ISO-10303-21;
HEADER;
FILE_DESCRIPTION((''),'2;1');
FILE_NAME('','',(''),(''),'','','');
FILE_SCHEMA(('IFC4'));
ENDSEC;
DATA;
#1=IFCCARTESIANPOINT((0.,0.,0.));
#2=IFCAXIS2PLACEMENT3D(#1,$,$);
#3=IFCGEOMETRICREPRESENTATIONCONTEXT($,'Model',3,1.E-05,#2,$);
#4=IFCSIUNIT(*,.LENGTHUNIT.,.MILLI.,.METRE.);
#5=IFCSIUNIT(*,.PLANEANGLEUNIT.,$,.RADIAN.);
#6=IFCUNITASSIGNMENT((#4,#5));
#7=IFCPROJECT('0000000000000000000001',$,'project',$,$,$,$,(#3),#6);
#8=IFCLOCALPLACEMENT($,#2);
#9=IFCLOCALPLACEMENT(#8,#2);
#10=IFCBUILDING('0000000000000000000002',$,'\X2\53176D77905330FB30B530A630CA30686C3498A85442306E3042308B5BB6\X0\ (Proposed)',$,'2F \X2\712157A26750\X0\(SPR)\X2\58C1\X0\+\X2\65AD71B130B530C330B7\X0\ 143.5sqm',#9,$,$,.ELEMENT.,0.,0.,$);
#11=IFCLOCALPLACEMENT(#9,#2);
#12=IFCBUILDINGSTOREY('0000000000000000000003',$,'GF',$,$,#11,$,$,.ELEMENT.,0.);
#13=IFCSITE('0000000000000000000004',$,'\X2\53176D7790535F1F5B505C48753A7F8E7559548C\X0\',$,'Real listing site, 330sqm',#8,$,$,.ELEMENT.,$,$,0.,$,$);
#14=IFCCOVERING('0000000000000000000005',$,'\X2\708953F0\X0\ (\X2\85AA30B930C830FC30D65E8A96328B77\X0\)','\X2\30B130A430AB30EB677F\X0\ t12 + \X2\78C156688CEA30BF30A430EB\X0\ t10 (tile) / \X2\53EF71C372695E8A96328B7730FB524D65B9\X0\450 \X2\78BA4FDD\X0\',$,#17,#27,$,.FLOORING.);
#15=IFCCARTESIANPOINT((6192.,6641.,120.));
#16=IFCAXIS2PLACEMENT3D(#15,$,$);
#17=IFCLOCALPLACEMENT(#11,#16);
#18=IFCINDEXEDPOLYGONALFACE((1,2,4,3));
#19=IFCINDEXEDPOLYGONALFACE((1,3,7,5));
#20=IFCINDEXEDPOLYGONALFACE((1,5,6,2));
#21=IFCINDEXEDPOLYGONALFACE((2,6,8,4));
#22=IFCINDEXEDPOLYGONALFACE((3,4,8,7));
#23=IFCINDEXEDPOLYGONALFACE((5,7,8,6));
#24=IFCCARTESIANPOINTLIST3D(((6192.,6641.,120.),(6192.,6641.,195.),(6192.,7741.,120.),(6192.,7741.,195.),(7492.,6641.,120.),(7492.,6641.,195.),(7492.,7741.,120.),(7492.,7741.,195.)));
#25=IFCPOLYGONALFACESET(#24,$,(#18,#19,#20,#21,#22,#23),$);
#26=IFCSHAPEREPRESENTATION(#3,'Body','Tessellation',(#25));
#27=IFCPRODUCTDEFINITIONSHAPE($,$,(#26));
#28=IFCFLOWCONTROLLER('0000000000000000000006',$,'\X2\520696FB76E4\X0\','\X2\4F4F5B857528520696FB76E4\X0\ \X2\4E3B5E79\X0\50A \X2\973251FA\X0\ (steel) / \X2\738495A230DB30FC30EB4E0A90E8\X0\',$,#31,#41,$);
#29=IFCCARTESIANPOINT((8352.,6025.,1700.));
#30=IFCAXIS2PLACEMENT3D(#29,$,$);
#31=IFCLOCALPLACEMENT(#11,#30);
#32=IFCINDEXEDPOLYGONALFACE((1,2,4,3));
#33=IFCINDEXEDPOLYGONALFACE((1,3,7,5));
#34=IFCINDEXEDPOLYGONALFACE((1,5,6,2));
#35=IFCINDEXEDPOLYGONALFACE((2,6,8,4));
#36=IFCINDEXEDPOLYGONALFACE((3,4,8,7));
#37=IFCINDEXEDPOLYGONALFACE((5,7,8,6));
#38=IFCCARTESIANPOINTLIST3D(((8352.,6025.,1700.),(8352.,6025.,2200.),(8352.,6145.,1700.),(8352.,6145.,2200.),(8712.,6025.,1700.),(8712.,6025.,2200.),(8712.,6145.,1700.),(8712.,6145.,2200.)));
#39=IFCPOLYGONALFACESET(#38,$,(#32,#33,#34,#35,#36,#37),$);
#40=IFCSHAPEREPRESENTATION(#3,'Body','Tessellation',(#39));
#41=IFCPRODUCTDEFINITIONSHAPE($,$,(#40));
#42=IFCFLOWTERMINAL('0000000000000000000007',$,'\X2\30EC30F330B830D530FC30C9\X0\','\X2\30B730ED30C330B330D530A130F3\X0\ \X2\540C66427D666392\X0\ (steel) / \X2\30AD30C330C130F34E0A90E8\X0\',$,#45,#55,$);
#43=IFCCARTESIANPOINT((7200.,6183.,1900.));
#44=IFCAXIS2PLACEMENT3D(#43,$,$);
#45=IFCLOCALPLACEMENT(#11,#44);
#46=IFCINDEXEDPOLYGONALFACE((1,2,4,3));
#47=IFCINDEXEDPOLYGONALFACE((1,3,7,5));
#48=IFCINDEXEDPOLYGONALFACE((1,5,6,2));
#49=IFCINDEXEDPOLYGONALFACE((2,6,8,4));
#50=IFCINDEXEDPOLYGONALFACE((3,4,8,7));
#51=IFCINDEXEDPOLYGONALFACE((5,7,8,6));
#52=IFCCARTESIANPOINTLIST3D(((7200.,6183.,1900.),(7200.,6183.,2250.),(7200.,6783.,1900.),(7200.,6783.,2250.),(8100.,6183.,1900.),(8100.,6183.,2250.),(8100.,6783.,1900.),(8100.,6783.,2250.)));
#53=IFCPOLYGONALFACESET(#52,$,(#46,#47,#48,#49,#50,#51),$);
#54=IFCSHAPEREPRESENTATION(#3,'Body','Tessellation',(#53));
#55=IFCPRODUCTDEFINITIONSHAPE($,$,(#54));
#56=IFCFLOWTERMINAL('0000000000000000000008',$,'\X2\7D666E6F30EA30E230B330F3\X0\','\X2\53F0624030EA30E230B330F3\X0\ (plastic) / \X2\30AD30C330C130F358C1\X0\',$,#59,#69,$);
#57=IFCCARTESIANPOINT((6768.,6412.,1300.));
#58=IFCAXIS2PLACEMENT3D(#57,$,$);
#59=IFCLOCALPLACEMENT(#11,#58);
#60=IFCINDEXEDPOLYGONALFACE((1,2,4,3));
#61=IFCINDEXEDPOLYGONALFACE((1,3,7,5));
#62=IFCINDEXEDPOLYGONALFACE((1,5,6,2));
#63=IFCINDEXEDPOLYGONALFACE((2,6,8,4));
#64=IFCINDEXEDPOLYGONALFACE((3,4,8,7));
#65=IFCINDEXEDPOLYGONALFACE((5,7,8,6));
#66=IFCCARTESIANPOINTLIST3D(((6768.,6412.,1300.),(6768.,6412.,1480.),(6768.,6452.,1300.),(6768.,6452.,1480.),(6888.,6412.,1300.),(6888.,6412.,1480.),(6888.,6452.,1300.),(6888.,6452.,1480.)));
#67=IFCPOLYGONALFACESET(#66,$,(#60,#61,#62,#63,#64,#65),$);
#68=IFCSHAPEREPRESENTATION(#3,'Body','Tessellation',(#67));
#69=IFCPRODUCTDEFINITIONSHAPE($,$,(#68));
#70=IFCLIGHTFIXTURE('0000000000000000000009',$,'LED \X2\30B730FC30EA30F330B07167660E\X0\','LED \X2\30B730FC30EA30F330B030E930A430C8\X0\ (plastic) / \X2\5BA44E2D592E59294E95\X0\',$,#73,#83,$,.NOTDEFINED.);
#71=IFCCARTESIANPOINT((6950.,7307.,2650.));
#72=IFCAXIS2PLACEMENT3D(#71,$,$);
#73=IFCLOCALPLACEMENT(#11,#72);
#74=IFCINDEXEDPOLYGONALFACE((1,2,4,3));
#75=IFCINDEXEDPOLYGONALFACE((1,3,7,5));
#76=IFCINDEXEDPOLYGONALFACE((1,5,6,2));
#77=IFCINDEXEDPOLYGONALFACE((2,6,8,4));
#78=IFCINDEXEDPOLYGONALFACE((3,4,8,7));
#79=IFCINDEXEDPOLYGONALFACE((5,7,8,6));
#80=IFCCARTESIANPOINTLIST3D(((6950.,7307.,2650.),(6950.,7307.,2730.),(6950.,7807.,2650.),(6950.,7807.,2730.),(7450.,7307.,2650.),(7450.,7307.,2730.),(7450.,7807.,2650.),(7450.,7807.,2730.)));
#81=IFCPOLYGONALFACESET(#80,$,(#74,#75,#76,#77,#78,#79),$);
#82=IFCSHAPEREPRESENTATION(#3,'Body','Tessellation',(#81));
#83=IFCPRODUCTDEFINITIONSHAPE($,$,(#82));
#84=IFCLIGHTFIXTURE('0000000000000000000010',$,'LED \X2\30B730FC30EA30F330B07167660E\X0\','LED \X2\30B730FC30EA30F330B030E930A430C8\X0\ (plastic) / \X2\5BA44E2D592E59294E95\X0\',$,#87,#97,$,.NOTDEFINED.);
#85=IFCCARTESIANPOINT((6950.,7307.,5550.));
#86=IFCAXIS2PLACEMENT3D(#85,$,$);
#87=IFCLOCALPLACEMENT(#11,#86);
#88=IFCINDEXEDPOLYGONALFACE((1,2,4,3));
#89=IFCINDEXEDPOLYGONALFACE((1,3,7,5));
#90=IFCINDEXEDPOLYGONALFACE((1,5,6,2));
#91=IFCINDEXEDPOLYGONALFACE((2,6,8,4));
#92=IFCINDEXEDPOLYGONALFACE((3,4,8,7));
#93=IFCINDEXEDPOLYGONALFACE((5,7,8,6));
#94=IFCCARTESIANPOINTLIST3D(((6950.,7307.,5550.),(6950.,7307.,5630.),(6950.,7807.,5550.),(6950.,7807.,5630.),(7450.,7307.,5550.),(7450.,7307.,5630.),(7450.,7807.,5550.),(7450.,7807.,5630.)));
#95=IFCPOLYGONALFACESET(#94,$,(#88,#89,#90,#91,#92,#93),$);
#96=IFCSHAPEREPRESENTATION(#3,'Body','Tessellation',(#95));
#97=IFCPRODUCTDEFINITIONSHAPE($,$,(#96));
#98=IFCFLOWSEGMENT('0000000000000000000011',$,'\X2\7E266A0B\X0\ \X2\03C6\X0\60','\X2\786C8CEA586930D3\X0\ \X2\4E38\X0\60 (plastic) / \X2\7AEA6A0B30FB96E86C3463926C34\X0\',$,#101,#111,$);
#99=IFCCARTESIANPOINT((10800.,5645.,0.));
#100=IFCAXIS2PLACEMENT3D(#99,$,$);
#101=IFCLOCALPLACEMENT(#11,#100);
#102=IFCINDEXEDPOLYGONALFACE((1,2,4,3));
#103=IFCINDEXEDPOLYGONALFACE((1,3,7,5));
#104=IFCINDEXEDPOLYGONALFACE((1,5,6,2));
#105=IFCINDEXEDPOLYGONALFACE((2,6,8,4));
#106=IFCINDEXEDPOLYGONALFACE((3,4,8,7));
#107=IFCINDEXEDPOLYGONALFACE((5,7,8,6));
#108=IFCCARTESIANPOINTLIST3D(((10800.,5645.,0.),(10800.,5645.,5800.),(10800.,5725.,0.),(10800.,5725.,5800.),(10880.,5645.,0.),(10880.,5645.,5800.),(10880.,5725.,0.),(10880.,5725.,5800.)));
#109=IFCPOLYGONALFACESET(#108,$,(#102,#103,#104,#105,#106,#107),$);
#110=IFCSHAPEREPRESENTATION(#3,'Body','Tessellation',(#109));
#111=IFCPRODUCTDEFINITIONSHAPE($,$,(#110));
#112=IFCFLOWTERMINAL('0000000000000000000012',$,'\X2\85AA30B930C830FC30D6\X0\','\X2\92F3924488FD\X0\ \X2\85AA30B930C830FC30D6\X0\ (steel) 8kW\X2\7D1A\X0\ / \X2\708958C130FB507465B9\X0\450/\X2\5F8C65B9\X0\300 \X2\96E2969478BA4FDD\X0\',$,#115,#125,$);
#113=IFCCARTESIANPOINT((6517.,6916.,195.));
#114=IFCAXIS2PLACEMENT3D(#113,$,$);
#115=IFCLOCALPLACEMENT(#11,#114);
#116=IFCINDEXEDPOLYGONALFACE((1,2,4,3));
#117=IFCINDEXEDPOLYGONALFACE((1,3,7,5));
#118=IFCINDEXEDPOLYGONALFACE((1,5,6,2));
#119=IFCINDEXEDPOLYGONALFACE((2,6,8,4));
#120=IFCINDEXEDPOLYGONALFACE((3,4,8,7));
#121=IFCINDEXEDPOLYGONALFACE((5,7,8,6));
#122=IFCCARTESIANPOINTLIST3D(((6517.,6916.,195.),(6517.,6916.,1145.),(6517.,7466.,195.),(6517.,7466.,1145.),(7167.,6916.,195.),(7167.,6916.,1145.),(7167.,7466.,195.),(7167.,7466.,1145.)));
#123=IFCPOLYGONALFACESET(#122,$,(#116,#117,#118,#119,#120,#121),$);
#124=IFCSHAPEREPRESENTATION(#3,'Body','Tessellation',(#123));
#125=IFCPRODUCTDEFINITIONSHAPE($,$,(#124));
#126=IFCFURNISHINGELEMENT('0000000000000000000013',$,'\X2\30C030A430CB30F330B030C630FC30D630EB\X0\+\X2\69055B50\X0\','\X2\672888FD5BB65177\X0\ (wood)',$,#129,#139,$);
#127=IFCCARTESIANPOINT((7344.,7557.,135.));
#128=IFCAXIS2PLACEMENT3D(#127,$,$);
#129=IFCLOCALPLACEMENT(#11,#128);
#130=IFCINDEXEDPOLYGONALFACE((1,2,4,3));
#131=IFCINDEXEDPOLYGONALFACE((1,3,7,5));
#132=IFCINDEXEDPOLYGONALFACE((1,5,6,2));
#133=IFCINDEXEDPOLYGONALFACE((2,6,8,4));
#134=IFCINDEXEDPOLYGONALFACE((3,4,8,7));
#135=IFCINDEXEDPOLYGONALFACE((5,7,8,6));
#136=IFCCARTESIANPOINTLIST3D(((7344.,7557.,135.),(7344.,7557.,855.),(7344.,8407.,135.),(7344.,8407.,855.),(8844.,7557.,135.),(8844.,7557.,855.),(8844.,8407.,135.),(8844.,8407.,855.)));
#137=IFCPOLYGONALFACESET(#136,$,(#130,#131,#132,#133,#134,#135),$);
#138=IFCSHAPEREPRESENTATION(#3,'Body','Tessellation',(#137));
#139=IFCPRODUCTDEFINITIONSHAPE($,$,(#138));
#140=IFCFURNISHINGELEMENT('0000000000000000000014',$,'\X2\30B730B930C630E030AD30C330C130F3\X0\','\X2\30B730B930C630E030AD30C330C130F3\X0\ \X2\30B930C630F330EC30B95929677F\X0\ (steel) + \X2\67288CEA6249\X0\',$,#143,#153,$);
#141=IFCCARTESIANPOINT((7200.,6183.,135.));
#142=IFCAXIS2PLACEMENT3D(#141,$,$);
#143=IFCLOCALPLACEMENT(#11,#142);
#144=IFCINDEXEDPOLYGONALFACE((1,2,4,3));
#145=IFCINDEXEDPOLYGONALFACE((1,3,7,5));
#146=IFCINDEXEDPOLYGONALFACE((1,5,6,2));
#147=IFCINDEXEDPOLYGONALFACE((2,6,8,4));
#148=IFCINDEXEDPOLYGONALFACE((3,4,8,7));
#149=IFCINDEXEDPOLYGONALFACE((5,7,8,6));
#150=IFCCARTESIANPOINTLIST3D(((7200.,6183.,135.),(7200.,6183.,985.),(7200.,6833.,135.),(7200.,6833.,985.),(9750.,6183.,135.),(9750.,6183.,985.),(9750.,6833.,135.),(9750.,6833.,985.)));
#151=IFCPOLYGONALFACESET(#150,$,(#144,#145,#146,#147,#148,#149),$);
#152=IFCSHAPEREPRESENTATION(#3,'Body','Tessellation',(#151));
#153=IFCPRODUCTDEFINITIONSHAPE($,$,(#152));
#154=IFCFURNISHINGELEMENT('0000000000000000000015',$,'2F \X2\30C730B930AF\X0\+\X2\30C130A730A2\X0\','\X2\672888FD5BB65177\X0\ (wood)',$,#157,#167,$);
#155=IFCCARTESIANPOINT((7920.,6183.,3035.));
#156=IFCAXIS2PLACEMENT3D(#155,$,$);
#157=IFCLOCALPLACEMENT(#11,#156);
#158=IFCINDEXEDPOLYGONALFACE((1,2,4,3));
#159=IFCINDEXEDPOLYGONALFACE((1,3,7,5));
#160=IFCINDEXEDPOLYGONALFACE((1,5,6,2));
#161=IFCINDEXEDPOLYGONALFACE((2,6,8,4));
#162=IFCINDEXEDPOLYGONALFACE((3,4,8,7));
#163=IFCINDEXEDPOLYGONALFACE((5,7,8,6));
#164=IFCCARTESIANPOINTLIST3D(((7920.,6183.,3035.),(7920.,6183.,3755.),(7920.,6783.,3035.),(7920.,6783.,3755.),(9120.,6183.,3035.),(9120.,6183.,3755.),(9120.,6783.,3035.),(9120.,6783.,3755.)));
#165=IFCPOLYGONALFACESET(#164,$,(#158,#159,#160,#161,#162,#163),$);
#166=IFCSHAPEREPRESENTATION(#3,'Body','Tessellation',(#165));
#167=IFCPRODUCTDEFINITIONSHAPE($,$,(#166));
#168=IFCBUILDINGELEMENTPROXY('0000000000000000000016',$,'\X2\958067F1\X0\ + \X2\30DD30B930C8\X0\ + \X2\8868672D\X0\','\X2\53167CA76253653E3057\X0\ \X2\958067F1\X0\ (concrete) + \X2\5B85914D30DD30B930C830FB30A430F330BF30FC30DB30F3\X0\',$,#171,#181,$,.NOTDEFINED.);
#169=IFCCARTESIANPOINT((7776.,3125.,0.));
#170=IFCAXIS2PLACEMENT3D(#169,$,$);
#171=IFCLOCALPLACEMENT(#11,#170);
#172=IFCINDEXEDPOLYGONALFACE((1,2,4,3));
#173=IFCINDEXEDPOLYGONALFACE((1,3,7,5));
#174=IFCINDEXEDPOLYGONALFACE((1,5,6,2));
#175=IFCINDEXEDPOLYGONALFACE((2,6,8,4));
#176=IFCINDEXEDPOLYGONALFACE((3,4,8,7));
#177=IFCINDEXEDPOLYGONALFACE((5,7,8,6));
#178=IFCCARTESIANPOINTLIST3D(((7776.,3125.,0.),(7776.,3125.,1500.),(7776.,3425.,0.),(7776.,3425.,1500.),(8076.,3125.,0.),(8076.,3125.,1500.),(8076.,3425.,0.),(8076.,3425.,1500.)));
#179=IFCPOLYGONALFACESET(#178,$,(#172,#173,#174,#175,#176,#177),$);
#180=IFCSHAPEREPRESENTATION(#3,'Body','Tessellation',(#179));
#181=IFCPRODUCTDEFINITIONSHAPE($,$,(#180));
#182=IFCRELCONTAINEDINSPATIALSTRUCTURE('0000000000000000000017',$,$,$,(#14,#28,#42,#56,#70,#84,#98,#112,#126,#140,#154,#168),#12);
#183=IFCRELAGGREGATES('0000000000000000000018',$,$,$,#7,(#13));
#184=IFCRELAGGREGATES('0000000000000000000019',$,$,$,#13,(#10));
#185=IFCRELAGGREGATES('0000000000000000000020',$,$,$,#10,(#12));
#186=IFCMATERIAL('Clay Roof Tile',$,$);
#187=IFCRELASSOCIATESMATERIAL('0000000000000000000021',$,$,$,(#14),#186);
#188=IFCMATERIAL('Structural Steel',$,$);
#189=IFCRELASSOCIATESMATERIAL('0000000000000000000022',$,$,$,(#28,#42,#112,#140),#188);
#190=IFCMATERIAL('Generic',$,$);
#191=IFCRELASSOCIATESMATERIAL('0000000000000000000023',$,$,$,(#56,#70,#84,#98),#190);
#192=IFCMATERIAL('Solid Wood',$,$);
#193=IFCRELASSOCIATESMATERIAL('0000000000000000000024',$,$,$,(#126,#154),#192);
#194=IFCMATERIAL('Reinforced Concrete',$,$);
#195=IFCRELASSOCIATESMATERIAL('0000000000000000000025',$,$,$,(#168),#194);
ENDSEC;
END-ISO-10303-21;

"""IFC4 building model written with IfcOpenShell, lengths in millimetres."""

from ifc_helpers import new_model, si_unit, frame, frame_2d, origin, place, context, project, spatial, rectangle, extrude, material, element, save


model = new_model("IFC4")

# Units and contexts
model_context = context("Model", 3, precision=1e-05, world=origin())
ifc_project = project(units=[si_unit("LENGTHUNIT", "METRE", prefix="MILLI"), si_unit("PLANEANGLEUNIT", "RADIAN")], contexts=[model_context])

# Site, building, storey
site_placement = place(None, origin())
site = spatial("IfcSite", under=ifc_project, at=site_placement, Name="北海道弟子屈町美留和", ObjectType="Real listing site, 330sqm", CompositionType="ELEMENT", RefElevation=0.0)
building_placement = place(site_placement, origin())
building = spatial("IfcBuilding", under=site, at=building_placement, Name="北海道・サウナと水風呂のある家 (Proposed)", ObjectType="2F 無垢材(SPR)壁+断熱サッシ 143.5sqm", CompositionType="ELEMENT", ElevationOfRefHeight=0.0, ElevationOfTerrain=0.0)
storey_placement = place(building_placement, origin())
storey = spatial("IfcBuildingStorey", under=building, at=storey_placement, Name="GF", CompositionType="ELEMENT", Elevation=0.0)

# Shared definitions
ifc_material_1 = material(Name="Solid Wood")

# Shared definitions
ifc_material_2 = material(Name="Structural Steel")

# Covering
ifc_material_3 = material(Name="Reinforced Concrete")
ifc_material_4 = material(Name="Clay Roof Tile")
covering_1_placement = place(storey_placement, frame((6192.0, 6641.0, 120.0)))
element("IfcCovering", 1, at=covering_1_placement, inside=storey, material=ifc_material_4, Name="炉台 (薪ストーブ床防護)", Description="ケイカル板 t12 + 磁器質タイル t10 (tile) / 可燃物床防護・前方450 確保", PredefinedType="FLOORING", context=model_context, shape_type="SweptSolid", body=[
    extrude(rectangle(XDim=1300.0, YDim=1100.0, at=frame_2d((650.0, 550.0))), frame((6192.0, 6641.0, 120.0)), (0.0, 0.0, 1.0), 75.0),
])

# Flow controller
flow_controller_placement = place(storey_placement, frame((8352.0, 6025.0, 1700.0)))
element("IfcFlowController", 2, at=flow_controller_placement, inside=storey, material=ifc_material_2, Name="分電盤", Description="住宅用分電盤 主幹50A 露出 (steel) / 玄関ホール上部", context=model_context, shape_type="SweptSolid", body=[
    extrude(rectangle(XDim=360.0, YDim=120.0, at=frame_2d((180.0, 60.0))), frame((8352.0, 6025.0, 1700.0)), (0.0, 0.0, 1.0), 500.0),
])

# Flow terminals
flow_terminal_1_placement = place(storey_placement, frame((7200.0, 6183.0, 1900.0)))
element("IfcFlowTerminal", 3, at=flow_terminal_1_placement, inside=storey, material=ifc_material_2, Name="レンジフード", Description="シロッコファン 同時給排 (steel) / キッチン上部", context=model_context, shape_type="SweptSolid", body=[
    extrude(rectangle(XDim=900.0, YDim=600.0, at=frame_2d((450.0, 300.0))), frame((7200.0, 6183.0, 1900.0)), (0.0, 0.0, 1.0), 350.0),
])
ifc_material_5 = material(Name="Generic")
flow_terminal_2_placement = place(storey_placement, frame((6768.0, 6412.0, 1300.0)))
element("IfcFlowTerminal", 4, at=flow_terminal_2_placement, inside=storey, material=ifc_material_5, Name="給湯リモコン", Description="台所リモコン (plastic) / キッチン壁", context=model_context, shape_type="SweptSolid", body=[
    extrude(rectangle(XDim=120.0, YDim=40.0, at=frame_2d((60.0, 20.0))), frame((6768.0, 6412.0, 1300.0)), (0.0, 0.0, 1.0), 180.0),
])

# Light fixtures
light_fixture_1_placement = place(storey_placement, frame((6950.0, 7307.0, 2650.0)))
element("IfcLightFixture", 5, at=light_fixture_1_placement, inside=storey, material=ifc_material_5, Name="LED シーリング照明", Description="LED シーリングライト (plastic) / 室中央天井", PredefinedType="NOTDEFINED", context=model_context, shape_type="SweptSolid", body=[
    extrude(rectangle(XDim=500.0, YDim=500.0, at=frame_2d((250.0, 250.0))), frame((6950.0, 7307.0, 2650.0)), (0.0, 0.0, 1.0), 80.0),
])
light_fixture_2_placement = place(storey_placement, frame((6950.0, 7307.0, 5550.0)))
element("IfcLightFixture", 6, at=light_fixture_2_placement, inside=storey, material=ifc_material_5, Name="LED シーリング照明", Description="LED シーリングライト (plastic) / 室中央天井", PredefinedType="NOTDEFINED", context=model_context, shape_type="SweptSolid", body=[
    extrude(rectangle(XDim=500.0, YDim=500.0, at=frame_2d((250.0, 250.0))), frame((6950.0, 7307.0, 5550.0)), (0.0, 0.0, 1.0), 80.0),
])

# Flow segment
flow_segment_placement = place(storey_placement, frame((10800.0, 5645.0, 0.0)))
element("IfcFlowSegment", 7, at=flow_segment_placement, inside=storey, material=ifc_material_5, Name="縦樋 φ60", Description="硬質塩ビ 丸60 (plastic) / 竪樋・雨水排水", context=model_context, shape_type="SweptSolid", body=[
    extrude(rectangle(XDim=80.0, YDim=80.0, at=frame_2d((40.0, 40.0))), frame((10800.0, 5645.0, 0.0)), (0.0, 0.0, 1.0), 5800.0),
])

# Flow terminal
flow_terminal_3_placement = place(storey_placement, frame((6517.0, 6916.0, 195.0)))
element("IfcFlowTerminal", 8, at=flow_terminal_3_placement, inside=storey, material=ifc_material_2, Name="薪ストーブ", Description="鋳鉄製 薪ストーブ (steel) 8kW級 / 炉壁・側方450/後方300 離隔確保", context=model_context, shape_type="SweptSolid", body=[
    extrude(rectangle(XDim=650.0, YDim=550.0, at=frame_2d((325.0, 275.0))), frame((6517.0, 6916.0, 195.0)), (0.0, 0.0, 1.0), 950.0),
])

# Furnishing elements
furnishing_1_placement = place(storey_placement, frame((7344.0, 7557.0, 135.0)))
element("IfcFurnishingElement", 9, at=furnishing_1_placement, inside=storey, material=ifc_material_1, Name="ダイニングテーブル+椅子", Description="木製家具 (wood)", context=model_context, shape_type="SweptSolid", body=[
    extrude(rectangle(XDim=1500.0, YDim=850.0, at=frame_2d((750.0, 425.0))), frame((7344.0, 7557.0, 135.0)), (0.0, 0.0, 1.0), 720.0),
])
furnishing_2_placement = place(storey_placement, frame((7200.0, 6183.0, 135.0)))
element("IfcFurnishingElement", 10, at=furnishing_2_placement, inside=storey, material=ifc_material_2, Name="システムキッチン", Description="システムキッチン ステンレス天板 (steel) + 木質扉", context=model_context, shape_type="SweptSolid", body=[
    extrude(rectangle(XDim=2550.0, YDim=650.0, at=frame_2d((1275.0, 325.0))), frame((7200.0, 6183.0, 135.0)), (0.0, 0.0, 1.0), 850.0),
])
furnishing_3_placement = place(storey_placement, frame((7920.0, 6183.0, 3035.0)))
element("IfcFurnishingElement", 11, at=furnishing_3_placement, inside=storey, material=ifc_material_1, Name="2F デスク+チェア", Description="木製家具 (wood)", context=model_context, shape_type="SweptSolid", body=[
    extrude(rectangle(XDim=1200.0, YDim=600.0, at=frame_2d((600.0, 300.0))), frame((7920.0, 6183.0, 3035.0)), (0.0, 0.0, 1.0), 720.0),
])

# Building element proxy
proxy_placement = place(storey_placement, frame((7776.0, 3125.0, 0.0)))
element("IfcBuildingElementProxy", 12, at=proxy_placement, inside=storey, material=ifc_material_3, Name="門柱 + ポスト + 表札", Description="化粧打放し 門柱 (concrete) + 宅配ポスト・インターホン", PredefinedType="NOTDEFINED", context=model_context, shape_type="SweptSolid", body=[
    extrude(rectangle(XDim=300.0, YDim=300.0, at=frame_2d((150.0, 150.0))), frame((7776.0, 3125.0, 0.0)), (0.0, 0.0, 1.0), 1500.0),
])

save(model, "model.ifc")
